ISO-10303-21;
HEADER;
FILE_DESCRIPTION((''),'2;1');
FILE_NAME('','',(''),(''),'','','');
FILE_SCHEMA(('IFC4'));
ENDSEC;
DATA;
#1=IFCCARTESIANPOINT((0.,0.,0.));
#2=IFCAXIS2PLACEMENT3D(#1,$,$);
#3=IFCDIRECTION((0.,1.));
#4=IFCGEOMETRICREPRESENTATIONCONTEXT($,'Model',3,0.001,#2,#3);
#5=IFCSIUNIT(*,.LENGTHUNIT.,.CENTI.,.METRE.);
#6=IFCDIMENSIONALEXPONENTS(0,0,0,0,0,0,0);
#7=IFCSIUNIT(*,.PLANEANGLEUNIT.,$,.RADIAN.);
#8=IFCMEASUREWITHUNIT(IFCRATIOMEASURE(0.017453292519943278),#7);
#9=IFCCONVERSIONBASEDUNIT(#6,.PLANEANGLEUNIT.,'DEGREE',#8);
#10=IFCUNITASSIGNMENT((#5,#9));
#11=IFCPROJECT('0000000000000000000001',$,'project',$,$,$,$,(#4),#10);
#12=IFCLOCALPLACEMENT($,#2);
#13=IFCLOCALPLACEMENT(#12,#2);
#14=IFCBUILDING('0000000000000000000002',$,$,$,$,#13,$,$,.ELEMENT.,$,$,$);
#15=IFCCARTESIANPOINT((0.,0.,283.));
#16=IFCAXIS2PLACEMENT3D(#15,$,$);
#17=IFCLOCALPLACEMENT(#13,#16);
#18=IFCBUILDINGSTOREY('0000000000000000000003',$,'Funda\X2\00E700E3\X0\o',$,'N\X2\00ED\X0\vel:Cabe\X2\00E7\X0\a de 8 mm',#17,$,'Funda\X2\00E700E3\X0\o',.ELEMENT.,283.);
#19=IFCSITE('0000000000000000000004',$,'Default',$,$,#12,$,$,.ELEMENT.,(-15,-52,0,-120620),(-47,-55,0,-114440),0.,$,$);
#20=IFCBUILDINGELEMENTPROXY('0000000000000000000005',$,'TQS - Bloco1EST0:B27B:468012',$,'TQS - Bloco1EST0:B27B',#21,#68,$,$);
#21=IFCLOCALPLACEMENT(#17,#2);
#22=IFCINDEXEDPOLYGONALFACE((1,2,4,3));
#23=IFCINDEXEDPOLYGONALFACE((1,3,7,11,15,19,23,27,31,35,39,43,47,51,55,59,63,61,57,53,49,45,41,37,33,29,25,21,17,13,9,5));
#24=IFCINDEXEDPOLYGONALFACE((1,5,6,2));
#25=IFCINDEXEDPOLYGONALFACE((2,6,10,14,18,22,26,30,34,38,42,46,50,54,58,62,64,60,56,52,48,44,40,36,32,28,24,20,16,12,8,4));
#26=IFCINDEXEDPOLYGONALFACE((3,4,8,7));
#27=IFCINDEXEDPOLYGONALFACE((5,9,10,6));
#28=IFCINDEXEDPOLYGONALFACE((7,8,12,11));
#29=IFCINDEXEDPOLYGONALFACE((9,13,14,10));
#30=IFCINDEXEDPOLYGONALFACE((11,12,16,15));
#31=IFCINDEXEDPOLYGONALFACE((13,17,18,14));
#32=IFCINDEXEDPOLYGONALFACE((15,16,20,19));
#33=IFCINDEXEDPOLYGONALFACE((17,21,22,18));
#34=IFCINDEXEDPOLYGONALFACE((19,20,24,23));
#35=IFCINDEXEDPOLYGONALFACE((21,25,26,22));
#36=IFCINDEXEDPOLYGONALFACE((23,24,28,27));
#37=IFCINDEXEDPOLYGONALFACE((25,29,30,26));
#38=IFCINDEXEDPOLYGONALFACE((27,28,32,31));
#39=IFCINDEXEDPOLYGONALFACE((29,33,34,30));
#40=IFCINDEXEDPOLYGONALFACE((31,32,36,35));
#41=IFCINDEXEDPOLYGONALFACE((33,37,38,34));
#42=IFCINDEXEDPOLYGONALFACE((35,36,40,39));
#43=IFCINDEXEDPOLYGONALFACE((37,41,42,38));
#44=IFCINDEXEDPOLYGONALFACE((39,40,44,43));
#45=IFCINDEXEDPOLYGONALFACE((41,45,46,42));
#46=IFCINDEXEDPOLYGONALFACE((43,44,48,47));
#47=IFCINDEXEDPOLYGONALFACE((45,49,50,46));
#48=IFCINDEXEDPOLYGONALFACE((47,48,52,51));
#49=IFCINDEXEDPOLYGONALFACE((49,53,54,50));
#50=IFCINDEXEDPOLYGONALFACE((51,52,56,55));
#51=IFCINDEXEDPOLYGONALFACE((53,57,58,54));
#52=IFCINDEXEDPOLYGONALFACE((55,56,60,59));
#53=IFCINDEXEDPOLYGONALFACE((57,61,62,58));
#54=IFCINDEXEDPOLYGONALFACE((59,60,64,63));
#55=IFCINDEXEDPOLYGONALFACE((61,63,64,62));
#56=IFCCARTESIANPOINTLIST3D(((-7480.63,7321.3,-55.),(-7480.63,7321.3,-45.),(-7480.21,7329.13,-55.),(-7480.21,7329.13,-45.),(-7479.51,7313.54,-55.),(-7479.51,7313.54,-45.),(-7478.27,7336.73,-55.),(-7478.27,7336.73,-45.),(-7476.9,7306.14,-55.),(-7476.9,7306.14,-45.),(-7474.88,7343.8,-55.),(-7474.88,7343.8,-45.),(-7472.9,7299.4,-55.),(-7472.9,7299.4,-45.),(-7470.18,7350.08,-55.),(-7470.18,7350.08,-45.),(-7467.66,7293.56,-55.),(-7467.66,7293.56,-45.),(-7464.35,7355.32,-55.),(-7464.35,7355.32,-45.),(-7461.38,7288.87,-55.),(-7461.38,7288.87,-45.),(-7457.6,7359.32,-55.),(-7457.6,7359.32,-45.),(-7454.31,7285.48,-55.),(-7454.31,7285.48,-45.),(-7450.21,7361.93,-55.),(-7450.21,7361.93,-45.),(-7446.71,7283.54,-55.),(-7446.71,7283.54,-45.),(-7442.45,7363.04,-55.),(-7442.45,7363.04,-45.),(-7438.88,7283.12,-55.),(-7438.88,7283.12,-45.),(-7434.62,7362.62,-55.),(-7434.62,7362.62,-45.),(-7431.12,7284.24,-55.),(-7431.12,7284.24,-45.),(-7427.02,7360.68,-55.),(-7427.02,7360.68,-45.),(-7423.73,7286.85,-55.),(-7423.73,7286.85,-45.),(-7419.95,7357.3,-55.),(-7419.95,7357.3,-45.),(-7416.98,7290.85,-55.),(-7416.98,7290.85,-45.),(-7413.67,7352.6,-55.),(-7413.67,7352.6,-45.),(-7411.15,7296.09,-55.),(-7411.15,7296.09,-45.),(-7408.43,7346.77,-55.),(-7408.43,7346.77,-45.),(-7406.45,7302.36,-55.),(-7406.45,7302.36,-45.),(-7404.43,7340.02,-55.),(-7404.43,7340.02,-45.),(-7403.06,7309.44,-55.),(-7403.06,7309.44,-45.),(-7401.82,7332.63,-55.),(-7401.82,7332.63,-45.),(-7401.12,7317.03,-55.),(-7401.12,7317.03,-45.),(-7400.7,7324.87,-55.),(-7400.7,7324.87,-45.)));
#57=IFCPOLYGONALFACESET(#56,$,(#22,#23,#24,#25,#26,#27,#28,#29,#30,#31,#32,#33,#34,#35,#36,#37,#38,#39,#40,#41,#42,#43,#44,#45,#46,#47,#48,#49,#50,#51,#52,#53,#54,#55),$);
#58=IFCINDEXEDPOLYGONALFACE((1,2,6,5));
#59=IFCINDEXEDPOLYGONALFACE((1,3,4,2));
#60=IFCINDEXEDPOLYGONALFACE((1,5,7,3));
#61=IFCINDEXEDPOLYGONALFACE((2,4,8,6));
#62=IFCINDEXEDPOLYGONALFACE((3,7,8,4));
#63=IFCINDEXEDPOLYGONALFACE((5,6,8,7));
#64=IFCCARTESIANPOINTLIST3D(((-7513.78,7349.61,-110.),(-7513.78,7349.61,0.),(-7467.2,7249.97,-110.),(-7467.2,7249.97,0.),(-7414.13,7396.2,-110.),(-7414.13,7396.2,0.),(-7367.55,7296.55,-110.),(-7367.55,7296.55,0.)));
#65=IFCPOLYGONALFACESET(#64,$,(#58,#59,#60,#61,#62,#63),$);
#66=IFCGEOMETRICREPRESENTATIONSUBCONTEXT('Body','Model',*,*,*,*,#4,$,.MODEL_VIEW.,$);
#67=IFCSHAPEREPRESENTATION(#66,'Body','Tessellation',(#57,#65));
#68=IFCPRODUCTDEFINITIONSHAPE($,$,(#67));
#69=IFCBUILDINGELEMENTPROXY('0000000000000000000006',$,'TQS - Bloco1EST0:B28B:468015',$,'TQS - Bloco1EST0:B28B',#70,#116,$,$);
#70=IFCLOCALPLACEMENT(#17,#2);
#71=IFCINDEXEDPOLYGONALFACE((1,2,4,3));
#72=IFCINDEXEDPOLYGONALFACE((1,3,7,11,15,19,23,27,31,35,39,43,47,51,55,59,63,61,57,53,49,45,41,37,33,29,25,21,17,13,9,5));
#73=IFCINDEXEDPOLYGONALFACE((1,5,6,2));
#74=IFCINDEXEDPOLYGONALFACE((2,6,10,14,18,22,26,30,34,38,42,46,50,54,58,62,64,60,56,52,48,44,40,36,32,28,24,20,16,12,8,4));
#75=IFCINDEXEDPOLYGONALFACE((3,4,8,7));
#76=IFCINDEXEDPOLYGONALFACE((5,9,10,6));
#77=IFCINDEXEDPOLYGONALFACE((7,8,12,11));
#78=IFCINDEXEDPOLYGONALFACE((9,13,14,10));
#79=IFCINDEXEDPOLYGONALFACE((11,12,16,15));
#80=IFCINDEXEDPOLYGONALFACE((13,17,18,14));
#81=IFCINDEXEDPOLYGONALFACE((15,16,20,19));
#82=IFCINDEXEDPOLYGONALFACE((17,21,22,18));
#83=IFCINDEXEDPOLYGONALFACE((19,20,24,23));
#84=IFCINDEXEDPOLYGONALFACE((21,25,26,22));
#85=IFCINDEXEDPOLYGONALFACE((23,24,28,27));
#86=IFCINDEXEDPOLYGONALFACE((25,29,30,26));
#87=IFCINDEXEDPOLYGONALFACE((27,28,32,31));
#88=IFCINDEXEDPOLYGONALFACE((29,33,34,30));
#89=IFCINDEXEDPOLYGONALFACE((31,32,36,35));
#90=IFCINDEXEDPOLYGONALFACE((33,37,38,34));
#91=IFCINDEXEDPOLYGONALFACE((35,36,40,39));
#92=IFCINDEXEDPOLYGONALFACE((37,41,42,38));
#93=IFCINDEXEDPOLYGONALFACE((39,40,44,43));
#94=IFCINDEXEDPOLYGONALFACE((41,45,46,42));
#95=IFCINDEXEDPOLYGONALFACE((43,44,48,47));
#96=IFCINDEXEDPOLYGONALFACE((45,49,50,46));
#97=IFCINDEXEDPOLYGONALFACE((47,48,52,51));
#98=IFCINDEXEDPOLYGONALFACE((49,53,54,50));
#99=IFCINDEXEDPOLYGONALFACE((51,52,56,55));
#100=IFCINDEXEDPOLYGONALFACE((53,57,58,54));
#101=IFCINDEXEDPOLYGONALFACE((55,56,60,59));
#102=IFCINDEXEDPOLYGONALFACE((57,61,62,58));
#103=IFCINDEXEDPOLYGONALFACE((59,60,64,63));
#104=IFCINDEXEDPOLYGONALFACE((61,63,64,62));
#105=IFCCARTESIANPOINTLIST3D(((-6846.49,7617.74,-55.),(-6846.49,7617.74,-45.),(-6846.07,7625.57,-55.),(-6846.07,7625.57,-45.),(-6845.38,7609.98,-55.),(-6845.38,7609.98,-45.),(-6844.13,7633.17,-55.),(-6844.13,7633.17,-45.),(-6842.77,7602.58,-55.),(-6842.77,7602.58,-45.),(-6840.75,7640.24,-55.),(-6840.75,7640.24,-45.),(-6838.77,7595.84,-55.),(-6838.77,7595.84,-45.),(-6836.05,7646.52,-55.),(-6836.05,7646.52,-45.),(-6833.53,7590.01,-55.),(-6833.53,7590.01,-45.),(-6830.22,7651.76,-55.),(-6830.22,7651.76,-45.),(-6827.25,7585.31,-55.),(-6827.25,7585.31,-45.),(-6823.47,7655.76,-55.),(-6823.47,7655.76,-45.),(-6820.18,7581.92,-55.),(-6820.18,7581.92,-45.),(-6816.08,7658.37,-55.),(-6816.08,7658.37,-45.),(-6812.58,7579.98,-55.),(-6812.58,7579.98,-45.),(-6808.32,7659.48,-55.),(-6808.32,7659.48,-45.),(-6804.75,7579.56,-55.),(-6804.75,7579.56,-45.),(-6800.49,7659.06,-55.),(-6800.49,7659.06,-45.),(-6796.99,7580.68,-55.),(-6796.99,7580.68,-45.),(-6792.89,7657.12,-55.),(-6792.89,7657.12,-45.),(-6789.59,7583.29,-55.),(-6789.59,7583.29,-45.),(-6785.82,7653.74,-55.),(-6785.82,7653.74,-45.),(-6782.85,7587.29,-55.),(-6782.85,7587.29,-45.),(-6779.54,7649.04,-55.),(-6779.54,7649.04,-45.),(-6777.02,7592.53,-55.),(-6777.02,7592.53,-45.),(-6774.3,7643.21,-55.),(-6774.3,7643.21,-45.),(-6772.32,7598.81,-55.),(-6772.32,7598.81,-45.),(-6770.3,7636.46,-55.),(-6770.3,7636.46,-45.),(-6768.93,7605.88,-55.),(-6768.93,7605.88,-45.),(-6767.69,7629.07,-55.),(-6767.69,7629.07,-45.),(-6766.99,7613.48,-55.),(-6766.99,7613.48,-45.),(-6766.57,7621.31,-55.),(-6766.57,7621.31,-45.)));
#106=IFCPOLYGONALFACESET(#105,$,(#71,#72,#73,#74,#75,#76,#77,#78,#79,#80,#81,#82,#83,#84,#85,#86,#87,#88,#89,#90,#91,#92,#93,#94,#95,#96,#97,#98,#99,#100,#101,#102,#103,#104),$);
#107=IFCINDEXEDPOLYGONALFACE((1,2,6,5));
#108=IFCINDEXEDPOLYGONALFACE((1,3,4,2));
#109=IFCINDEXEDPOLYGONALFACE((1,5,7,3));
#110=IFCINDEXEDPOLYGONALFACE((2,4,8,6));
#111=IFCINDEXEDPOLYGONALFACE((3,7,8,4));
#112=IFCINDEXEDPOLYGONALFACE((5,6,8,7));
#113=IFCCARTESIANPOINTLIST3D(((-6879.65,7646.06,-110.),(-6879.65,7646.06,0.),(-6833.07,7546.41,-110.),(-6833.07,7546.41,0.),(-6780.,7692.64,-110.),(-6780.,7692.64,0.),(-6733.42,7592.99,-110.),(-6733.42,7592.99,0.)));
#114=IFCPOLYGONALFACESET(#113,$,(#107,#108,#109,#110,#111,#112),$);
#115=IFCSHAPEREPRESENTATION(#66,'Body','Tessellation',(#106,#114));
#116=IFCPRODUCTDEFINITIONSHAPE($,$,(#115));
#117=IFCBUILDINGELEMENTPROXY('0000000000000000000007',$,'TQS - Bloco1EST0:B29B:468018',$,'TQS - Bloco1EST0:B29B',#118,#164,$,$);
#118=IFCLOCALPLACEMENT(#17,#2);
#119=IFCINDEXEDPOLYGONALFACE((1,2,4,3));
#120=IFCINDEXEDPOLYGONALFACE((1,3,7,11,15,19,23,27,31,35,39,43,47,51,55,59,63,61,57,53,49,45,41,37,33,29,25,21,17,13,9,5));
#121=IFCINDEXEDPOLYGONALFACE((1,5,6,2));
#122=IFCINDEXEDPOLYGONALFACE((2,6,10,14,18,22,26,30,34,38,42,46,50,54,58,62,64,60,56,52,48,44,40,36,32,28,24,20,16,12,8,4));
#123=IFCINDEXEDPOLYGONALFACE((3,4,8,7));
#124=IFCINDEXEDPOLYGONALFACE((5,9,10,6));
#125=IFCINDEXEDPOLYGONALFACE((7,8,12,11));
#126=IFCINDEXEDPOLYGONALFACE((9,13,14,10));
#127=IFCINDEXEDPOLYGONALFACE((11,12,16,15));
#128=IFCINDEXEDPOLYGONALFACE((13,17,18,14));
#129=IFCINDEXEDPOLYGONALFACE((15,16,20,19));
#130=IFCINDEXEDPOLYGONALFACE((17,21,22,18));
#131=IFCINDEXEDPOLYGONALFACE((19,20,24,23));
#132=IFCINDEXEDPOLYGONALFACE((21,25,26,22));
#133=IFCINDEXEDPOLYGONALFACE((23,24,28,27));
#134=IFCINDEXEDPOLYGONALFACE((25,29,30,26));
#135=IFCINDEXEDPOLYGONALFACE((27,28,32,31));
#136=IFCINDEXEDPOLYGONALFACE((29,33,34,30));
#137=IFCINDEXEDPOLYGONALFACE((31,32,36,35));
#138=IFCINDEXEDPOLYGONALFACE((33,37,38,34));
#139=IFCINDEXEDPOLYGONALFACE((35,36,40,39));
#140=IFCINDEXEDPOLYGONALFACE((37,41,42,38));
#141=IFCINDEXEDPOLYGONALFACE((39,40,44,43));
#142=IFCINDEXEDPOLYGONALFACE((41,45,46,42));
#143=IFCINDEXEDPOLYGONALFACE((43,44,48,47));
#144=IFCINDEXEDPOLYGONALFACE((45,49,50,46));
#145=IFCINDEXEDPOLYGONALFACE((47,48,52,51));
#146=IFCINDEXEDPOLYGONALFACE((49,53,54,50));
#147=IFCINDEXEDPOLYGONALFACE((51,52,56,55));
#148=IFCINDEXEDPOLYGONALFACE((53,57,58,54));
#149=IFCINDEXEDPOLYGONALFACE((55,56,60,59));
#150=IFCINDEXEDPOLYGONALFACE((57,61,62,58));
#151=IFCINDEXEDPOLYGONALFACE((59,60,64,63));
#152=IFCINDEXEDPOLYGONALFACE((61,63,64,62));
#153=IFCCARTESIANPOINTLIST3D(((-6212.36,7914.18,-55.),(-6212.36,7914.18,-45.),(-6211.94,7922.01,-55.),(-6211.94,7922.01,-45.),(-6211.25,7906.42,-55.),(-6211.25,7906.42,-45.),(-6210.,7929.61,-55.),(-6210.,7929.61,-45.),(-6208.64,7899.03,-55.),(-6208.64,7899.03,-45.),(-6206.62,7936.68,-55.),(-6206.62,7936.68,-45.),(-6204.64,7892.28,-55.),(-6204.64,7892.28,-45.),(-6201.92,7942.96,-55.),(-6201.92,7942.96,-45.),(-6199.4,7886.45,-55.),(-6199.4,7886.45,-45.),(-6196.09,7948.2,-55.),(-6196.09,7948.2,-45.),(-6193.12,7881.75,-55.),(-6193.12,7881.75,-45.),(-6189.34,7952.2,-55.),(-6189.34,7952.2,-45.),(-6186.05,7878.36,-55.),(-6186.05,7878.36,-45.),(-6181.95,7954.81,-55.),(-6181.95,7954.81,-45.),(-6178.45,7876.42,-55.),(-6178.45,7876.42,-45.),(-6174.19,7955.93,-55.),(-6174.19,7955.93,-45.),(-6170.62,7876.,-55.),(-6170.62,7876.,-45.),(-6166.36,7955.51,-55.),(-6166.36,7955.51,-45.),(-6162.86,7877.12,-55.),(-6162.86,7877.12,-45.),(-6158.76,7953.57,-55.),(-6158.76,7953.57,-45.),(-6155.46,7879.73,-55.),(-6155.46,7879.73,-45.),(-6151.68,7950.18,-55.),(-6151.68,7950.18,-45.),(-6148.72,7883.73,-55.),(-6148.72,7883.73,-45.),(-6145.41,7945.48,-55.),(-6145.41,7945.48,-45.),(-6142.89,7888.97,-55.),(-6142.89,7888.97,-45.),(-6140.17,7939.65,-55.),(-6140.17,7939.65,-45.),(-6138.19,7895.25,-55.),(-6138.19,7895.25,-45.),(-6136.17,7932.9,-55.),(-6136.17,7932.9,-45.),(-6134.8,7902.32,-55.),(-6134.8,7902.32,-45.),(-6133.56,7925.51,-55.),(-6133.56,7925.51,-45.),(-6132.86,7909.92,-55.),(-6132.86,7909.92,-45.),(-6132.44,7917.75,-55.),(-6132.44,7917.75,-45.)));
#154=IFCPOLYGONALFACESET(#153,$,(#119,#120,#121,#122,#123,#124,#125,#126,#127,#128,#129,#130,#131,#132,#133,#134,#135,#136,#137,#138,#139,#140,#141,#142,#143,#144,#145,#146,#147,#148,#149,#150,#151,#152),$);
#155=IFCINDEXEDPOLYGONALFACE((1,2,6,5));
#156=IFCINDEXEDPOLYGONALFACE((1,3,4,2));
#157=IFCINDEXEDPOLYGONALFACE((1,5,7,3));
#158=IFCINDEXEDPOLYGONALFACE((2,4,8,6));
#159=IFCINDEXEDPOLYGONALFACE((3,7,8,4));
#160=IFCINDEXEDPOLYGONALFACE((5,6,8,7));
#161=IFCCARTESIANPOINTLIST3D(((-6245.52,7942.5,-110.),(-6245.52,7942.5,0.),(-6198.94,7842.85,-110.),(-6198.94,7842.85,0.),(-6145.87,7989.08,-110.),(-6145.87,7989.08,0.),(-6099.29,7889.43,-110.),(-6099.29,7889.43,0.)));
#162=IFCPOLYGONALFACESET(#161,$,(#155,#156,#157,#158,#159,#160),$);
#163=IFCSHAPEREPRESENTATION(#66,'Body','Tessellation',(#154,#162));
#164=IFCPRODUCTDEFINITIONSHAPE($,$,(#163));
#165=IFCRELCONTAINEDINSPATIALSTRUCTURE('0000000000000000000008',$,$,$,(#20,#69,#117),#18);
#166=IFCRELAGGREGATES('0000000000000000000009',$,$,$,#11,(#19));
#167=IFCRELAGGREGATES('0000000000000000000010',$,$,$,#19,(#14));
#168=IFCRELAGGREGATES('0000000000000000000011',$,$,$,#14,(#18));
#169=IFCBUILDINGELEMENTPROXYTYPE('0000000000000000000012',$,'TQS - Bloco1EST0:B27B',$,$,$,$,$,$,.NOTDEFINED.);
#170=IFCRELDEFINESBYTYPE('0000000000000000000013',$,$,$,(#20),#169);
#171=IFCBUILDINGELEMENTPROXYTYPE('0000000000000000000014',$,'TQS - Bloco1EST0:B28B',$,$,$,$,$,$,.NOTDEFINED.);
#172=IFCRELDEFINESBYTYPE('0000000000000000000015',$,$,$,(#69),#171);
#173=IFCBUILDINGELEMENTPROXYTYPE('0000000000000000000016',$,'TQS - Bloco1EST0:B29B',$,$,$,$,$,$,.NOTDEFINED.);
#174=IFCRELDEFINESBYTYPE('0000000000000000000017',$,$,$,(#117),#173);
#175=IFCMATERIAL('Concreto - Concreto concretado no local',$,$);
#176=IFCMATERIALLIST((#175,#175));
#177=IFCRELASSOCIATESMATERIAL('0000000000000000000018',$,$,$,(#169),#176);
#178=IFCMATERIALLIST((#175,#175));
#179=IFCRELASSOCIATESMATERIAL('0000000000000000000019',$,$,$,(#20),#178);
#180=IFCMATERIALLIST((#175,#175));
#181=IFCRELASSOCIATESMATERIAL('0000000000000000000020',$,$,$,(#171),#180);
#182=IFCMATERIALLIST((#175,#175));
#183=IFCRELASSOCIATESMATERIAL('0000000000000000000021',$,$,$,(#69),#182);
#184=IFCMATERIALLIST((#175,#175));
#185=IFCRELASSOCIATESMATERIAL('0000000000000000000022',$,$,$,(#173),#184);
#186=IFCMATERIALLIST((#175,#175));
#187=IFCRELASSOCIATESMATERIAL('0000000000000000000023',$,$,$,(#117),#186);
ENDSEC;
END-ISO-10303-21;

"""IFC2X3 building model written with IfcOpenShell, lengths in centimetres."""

from ifc_helpers import new_model, entity, si_unit, converted_unit, direction, frame, frame_2d, origin, origin_2d_with_axis, place, context, subcontext, project, spatial, rectangle, circle, extrude, source, transform, mapped, material, material_list, type_object, type_shapes, element, save


model = new_model("IFC2X3")

# Units and contexts
model_context = context("Model", 3, precision=0.001, world=origin(), true_north=direction((0.0, 1.0)))
body_context = subcontext(model_context, "Body", "Model", "MODEL_VIEW")
ifc_project = project(units=[si_unit("LENGTHUNIT", "METRE", prefix="CENTI"), converted_unit("PLANEANGLEUNIT", "DEGREE", entity("IfcRatioMeasure", 0.017453292519943278), si_unit("PLANEANGLEUNIT", "RADIAN"), dimensions=[0, 0, 0, 0, 0, 0, 0])], contexts=[model_context])

# Site, building, storey
site_placement = place(None, origin())
site = spatial("IfcSite", under=ifc_project, at=site_placement, Name="Default", CompositionType="ELEMENT", RefLatitude=(-15, -52, 0, -120620), RefLongitude=(-47, -55, 0, -114440), RefElevation=0.0)
building_placement = place(site_placement, origin())
building = spatial("IfcBuilding", under=site, at=building_placement, CompositionType="ELEMENT")
storey_placement = place(building_placement, frame((0.0, 0.0, 283.0)))
storey = spatial("IfcBuildingStorey", under=building, at=storey_placement, Name="Fundação", ObjectType="Nível:Cabeça de 8 mm", LongName="Fundação", CompositionType="ELEMENT", Elevation=283.0)

# Building element proxies
ifc_material_1 = material(Name="Concreto - Concreto concretado no local")
ifc_material_list_1 = material_list([ifc_material_1, ifc_material_1])
ifc_material_list_2 = material_list([ifc_material_1, ifc_material_1])
building_element_proxy_type_1 = type_object("IfcBuildingElementProxyType", Name="TQS - Bloco1EST0:B27B", PredefinedType="NOTDEFINED", material=ifc_material_list_2)
shared_shape_1 = source(origin(), body_context, "Body", "SweptSolid", [
    extrude(circle(Radius=40.0, at=frame_2d((0.0, 0.0), x_axis=(1.0, 0.0))), frame((0.0, 0.0, -55.0)), (0.0, 0.0, 1.0), 10.0),
    extrude(rectangle(XDim=110.0, YDim=110.0, at=origin_2d_with_axis()), frame((0.0, 0.0, -110.0), z_axis=(0.0, 0.0, 1.0), x_axis=(-1.0, 0.0, 0.0)), (0.0, 0.0, 1.0), 110.0),
])
type_shapes(building_element_proxy_type_1, [shared_shape_1])
proxy_1_placement = place(storey_placement, frame((-7440.67, 7323.08, 0.0), z_axis=(0.0, 0.0, 1.0), x_axis=(0.905902, 0.423488, 0.0)))
element("IfcBuildingElementProxy", 1, at=proxy_1_placement, inside=storey, type_object=building_element_proxy_type_1, material=ifc_material_list_1, Name="TQS - Bloco1EST0:B27B:468012", ObjectType="TQS - Bloco1EST0:B27B", context=body_context, shape_type="MappedRepresentation", body=[
    mapped(shared_shape_1, transform((0.0, 0.0, 0.0), scale=1.0)),
])
ifc_material_list_3 = material_list([ifc_material_1, ifc_material_1])
ifc_material_list_4 = material_list([ifc_material_1, ifc_material_1])
building_element_proxy_type_2 = type_object("IfcBuildingElementProxyType", Name="TQS - Bloco1EST0:B28B", PredefinedType="NOTDEFINED", material=ifc_material_list_4)
shared_shape_2 = source(origin(), body_context, "Body", "SweptSolid", [
    extrude(circle(Radius=40.0, at=frame_2d((0.0, 0.0), x_axis=(1.0, 0.0))), frame((0.0, 0.0, -55.0)), (0.0, 0.0, 1.0), 10.0),
    extrude(rectangle(XDim=110.0, YDim=110.0, at=origin_2d_with_axis()), frame((0.0, 0.0, -110.0), z_axis=(0.0, 0.0, 1.0), x_axis=(-1.0, 0.0, 0.0)), (0.0, 0.0, 1.0), 110.0),
])
type_shapes(building_element_proxy_type_2, [shared_shape_2])
proxy_2_placement = place(storey_placement, frame((-6806.53, 7619.52, 0.0), z_axis=(0.0, 0.0, 1.0), x_axis=(0.905902, 0.423488, 0.0)))
element("IfcBuildingElementProxy", 2, at=proxy_2_placement, inside=storey, type_object=building_element_proxy_type_2, material=ifc_material_list_3, Name="TQS - Bloco1EST0:B28B:468015", ObjectType="TQS - Bloco1EST0:B28B", context=body_context, shape_type="MappedRepresentation", body=[
    mapped(shared_shape_2, transform((0.0, 0.0, 0.0), scale=1.0)),
])
ifc_material_list_5 = material_list([ifc_material_1, ifc_material_1])
ifc_material_list_6 = material_list([ifc_material_1, ifc_material_1])
building_element_proxy_type_3 = type_object("IfcBuildingElementProxyType", Name="TQS - Bloco1EST0:B29B", PredefinedType="NOTDEFINED", material=ifc_material_list_6)
shared_shape_3 = source(origin(), body_context, "Body", "SweptSolid", [
    extrude(circle(Radius=40.0, at=frame_2d((0.0, 0.0), x_axis=(1.0, 0.0))), frame((0.0, 0.0, -55.0)), (0.0, 0.0, 1.0), 10.0),
    extrude(rectangle(XDim=110.0, YDim=110.0, at=origin_2d_with_axis()), frame((0.0, 0.0, -110.0), z_axis=(0.0, 0.0, 1.0), x_axis=(-1.0, 0.0, 0.0)), (0.0, 0.0, 1.0), 110.0),
])
type_shapes(building_element_proxy_type_3, [shared_shape_3])
proxy_3_placement = place(storey_placement, frame((-6172.4, 7915.96, 0.0), z_axis=(0.0, 0.0, 1.0), x_axis=(0.905902, 0.423488, 0.0)))
element("IfcBuildingElementProxy", 3, at=proxy_3_placement, inside=storey, type_object=building_element_proxy_type_3, material=ifc_material_list_5, Name="TQS - Bloco1EST0:B29B:468018", ObjectType="TQS - Bloco1EST0:B29B", context=body_context, shape_type="MappedRepresentation", body=[
    mapped(shared_shape_3, transform((0.0, 0.0, 0.0), scale=1.0)),
])

save(model, "model.ifc")
